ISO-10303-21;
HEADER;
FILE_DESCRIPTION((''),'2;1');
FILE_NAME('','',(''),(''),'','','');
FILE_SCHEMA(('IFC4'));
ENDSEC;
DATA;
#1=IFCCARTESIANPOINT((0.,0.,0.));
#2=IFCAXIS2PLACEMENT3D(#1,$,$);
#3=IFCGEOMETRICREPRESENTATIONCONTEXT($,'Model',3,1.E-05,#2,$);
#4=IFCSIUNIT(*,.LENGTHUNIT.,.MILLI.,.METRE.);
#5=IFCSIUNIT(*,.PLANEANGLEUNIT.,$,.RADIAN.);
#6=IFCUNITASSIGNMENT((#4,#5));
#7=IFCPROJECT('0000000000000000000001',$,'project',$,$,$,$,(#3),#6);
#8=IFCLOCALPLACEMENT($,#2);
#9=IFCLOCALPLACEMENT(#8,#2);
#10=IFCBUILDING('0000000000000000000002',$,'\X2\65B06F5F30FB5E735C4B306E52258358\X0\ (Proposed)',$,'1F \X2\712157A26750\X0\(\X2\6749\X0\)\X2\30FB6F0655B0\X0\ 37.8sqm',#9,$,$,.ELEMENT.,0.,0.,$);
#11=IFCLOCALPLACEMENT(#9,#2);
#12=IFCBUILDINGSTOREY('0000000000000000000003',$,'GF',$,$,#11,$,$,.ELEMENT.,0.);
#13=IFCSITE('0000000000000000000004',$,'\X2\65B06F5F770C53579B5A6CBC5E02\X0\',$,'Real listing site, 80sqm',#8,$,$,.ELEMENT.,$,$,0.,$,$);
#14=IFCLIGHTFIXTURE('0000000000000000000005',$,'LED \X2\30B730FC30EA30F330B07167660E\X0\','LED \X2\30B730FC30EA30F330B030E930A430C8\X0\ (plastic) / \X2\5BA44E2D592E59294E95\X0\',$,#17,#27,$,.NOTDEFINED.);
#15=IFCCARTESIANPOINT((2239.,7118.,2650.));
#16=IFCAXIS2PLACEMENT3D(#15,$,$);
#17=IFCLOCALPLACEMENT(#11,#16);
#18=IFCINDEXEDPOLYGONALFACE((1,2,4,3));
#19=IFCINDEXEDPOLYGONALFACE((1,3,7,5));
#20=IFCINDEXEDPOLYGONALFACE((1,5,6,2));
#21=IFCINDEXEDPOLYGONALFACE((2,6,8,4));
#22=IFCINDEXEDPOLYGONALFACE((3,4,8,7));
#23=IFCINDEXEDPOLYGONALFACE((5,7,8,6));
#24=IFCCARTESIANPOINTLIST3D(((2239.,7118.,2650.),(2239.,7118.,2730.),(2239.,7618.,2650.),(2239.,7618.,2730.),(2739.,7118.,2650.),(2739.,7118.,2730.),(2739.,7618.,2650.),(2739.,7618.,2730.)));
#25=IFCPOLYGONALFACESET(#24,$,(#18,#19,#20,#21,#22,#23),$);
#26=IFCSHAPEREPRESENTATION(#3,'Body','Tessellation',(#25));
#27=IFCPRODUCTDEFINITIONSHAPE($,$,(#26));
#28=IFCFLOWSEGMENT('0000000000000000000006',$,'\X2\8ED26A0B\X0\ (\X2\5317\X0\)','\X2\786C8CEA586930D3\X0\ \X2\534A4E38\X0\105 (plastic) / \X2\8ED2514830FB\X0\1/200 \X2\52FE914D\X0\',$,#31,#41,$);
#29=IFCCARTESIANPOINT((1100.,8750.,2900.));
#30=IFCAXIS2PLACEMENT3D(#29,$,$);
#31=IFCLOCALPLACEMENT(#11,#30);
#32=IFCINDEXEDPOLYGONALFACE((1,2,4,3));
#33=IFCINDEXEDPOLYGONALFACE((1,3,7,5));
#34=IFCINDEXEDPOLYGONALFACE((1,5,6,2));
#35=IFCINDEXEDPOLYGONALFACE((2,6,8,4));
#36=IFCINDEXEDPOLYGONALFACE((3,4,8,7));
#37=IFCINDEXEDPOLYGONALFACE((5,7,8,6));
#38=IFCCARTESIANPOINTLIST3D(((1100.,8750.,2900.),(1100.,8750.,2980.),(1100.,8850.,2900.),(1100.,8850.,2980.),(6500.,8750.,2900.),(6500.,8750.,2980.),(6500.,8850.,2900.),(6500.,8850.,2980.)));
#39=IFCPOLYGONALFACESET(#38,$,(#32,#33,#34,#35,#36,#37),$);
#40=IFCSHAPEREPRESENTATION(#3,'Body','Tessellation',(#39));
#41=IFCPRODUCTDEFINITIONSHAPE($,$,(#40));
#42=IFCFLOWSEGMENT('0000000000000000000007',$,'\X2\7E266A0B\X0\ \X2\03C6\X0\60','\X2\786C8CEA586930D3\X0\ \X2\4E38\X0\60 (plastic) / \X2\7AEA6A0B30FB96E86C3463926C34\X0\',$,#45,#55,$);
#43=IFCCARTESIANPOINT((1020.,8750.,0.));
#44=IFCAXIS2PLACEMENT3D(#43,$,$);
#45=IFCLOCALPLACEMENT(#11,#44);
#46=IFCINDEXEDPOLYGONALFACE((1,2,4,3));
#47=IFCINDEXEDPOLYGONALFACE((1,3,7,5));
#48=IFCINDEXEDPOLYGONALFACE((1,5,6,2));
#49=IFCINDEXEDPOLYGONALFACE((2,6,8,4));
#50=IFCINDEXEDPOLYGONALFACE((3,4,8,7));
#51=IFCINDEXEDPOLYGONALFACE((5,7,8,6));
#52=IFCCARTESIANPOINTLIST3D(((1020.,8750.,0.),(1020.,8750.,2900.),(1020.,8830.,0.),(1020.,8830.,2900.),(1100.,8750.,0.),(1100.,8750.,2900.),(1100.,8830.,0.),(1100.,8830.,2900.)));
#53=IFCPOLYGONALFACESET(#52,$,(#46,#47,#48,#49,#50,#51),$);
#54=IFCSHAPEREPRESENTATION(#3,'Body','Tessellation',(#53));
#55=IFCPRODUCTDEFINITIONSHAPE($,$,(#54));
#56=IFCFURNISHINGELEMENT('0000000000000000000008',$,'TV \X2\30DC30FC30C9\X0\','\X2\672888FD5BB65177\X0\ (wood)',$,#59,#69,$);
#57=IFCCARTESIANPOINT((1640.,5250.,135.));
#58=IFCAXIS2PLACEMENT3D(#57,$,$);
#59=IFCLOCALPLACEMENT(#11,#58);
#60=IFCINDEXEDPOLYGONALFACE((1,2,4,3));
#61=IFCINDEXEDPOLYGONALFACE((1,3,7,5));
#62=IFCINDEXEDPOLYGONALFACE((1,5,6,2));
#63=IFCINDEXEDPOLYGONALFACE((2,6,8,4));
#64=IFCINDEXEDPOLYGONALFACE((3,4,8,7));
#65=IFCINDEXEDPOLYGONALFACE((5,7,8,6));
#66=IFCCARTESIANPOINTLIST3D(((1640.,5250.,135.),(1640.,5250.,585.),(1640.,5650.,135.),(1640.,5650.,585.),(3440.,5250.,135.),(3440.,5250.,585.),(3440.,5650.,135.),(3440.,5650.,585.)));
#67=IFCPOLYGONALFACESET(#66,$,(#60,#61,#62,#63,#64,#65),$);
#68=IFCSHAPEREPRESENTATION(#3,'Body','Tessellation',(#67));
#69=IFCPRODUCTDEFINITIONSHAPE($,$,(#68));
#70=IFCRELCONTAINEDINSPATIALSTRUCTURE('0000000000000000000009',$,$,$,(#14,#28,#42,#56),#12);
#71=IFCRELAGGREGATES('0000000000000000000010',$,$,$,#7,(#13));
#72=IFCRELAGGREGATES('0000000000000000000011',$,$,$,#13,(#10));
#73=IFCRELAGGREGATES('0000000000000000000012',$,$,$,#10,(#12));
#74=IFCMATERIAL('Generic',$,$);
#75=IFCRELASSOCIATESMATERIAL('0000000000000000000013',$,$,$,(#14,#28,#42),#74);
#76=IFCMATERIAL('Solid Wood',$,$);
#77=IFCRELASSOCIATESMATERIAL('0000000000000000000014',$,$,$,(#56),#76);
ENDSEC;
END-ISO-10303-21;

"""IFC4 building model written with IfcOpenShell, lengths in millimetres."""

from ifc_helpers import new_model, si_unit, frame, frame_2d, origin, place, context, project, spatial, rectangle, extrude, material, element, save


model = new_model("IFC4")

# Units and contexts
model_context = context("Model", 3, precision=1e-05, world=origin())
ifc_project = project(units=[si_unit("LENGTHUNIT", "METRE", prefix="MILLI"), si_unit("PLANEANGLEUNIT", "RADIAN")], contexts=[model_context])

# Site, building, storey
site_placement = place(None, origin())
site = spatial("IfcSite", under=ifc_project, at=site_placement, Name="新潟県南魚沼市", ObjectType="Real listing site, 80sqm", CompositionType="ELEMENT", RefElevation=0.0)
building_placement = place(site_placement, origin())
building = spatial("IfcBuilding", under=site, at=building_placement, Name="新潟・平屋の別荘 (Proposed)", ObjectType="1F 無垢材(杉)・漆喰 37.8sqm", CompositionType="ELEMENT", ElevationOfRefHeight=0.0, ElevationOfTerrain=0.0)
storey_placement = place(building_placement, origin())
storey = spatial("IfcBuildingStorey", under=building, at=storey_placement, Name="GF", CompositionType="ELEMENT", Elevation=0.0)

# Shared definitions
ifc_material_1 = material(Name="Solid Wood")

# Shared definitions
ifc_material_2 = material(Name="Generic")

# Light fixture
light_fixture_placement = place(storey_placement, frame((2239.0, 7118.0, 2650.0)))
element("IfcLightFixture", 1, at=light_fixture_placement, inside=storey, material=ifc_material_2, Name="LED シーリング照明", Description="LED シーリングライト (plastic) / 室中央天井", PredefinedType="NOTDEFINED", context=model_context, shape_type="SweptSolid", body=[
    extrude(rectangle(XDim=500.0, YDim=500.0, at=frame_2d((250.0, 250.0))), frame((2239.0, 7118.0, 2650.0)), (0.0, 0.0, 1.0), 80.0),
])

# Flow segments
flow_segment_1_placement = place(storey_placement, frame((1100.0, 8750.0, 2900.0)))
element("IfcFlowSegment", 2, at=flow_segment_1_placement, inside=storey, material=ifc_material_2, Name="軒樋 (北)", Description="硬質塩ビ 半丸105 (plastic) / 軒先・1/200 勾配", context=model_context, shape_type="SweptSolid", body=[
    extrude(rectangle(XDim=5400.0, YDim=100.0, at=frame_2d((2700.0, 50.0))), frame((1100.0, 8750.0, 2900.0)), (0.0, 0.0, 1.0), 80.0),
])
flow_segment_2_placement = place(storey_placement, frame((1020.0, 8750.0, 0.0)))
element("IfcFlowSegment", 3, at=flow_segment_2_placement, inside=storey, material=ifc_material_2, Name="縦樋 φ60", Description="硬質塩ビ 丸60 (plastic) / 竪樋・雨水排水", context=model_context, shape_type="SweptSolid", body=[
    extrude(rectangle(XDim=80.0, YDim=80.0, at=frame_2d((40.0, 40.0))), frame((1020.0, 8750.0, 0.0)), (0.0, 0.0, 1.0), 2900.0),
])

# Furnishing element
furnishing_placement = place(storey_placement, frame((1640.0, 5250.0, 135.0)))
element("IfcFurnishingElement", 4, at=furnishing_placement, inside=storey, material=ifc_material_1, Name="TV ボード", Description="木製家具 (wood)", context=model_context, shape_type="SweptSolid", body=[
    extrude(rectangle(XDim=1800.0, YDim=400.0, at=frame_2d((900.0, 200.0))), frame((1640.0, 5250.0, 135.0)), (0.0, 0.0, 1.0), 450.0),
])

save(model, "model.ifc")
